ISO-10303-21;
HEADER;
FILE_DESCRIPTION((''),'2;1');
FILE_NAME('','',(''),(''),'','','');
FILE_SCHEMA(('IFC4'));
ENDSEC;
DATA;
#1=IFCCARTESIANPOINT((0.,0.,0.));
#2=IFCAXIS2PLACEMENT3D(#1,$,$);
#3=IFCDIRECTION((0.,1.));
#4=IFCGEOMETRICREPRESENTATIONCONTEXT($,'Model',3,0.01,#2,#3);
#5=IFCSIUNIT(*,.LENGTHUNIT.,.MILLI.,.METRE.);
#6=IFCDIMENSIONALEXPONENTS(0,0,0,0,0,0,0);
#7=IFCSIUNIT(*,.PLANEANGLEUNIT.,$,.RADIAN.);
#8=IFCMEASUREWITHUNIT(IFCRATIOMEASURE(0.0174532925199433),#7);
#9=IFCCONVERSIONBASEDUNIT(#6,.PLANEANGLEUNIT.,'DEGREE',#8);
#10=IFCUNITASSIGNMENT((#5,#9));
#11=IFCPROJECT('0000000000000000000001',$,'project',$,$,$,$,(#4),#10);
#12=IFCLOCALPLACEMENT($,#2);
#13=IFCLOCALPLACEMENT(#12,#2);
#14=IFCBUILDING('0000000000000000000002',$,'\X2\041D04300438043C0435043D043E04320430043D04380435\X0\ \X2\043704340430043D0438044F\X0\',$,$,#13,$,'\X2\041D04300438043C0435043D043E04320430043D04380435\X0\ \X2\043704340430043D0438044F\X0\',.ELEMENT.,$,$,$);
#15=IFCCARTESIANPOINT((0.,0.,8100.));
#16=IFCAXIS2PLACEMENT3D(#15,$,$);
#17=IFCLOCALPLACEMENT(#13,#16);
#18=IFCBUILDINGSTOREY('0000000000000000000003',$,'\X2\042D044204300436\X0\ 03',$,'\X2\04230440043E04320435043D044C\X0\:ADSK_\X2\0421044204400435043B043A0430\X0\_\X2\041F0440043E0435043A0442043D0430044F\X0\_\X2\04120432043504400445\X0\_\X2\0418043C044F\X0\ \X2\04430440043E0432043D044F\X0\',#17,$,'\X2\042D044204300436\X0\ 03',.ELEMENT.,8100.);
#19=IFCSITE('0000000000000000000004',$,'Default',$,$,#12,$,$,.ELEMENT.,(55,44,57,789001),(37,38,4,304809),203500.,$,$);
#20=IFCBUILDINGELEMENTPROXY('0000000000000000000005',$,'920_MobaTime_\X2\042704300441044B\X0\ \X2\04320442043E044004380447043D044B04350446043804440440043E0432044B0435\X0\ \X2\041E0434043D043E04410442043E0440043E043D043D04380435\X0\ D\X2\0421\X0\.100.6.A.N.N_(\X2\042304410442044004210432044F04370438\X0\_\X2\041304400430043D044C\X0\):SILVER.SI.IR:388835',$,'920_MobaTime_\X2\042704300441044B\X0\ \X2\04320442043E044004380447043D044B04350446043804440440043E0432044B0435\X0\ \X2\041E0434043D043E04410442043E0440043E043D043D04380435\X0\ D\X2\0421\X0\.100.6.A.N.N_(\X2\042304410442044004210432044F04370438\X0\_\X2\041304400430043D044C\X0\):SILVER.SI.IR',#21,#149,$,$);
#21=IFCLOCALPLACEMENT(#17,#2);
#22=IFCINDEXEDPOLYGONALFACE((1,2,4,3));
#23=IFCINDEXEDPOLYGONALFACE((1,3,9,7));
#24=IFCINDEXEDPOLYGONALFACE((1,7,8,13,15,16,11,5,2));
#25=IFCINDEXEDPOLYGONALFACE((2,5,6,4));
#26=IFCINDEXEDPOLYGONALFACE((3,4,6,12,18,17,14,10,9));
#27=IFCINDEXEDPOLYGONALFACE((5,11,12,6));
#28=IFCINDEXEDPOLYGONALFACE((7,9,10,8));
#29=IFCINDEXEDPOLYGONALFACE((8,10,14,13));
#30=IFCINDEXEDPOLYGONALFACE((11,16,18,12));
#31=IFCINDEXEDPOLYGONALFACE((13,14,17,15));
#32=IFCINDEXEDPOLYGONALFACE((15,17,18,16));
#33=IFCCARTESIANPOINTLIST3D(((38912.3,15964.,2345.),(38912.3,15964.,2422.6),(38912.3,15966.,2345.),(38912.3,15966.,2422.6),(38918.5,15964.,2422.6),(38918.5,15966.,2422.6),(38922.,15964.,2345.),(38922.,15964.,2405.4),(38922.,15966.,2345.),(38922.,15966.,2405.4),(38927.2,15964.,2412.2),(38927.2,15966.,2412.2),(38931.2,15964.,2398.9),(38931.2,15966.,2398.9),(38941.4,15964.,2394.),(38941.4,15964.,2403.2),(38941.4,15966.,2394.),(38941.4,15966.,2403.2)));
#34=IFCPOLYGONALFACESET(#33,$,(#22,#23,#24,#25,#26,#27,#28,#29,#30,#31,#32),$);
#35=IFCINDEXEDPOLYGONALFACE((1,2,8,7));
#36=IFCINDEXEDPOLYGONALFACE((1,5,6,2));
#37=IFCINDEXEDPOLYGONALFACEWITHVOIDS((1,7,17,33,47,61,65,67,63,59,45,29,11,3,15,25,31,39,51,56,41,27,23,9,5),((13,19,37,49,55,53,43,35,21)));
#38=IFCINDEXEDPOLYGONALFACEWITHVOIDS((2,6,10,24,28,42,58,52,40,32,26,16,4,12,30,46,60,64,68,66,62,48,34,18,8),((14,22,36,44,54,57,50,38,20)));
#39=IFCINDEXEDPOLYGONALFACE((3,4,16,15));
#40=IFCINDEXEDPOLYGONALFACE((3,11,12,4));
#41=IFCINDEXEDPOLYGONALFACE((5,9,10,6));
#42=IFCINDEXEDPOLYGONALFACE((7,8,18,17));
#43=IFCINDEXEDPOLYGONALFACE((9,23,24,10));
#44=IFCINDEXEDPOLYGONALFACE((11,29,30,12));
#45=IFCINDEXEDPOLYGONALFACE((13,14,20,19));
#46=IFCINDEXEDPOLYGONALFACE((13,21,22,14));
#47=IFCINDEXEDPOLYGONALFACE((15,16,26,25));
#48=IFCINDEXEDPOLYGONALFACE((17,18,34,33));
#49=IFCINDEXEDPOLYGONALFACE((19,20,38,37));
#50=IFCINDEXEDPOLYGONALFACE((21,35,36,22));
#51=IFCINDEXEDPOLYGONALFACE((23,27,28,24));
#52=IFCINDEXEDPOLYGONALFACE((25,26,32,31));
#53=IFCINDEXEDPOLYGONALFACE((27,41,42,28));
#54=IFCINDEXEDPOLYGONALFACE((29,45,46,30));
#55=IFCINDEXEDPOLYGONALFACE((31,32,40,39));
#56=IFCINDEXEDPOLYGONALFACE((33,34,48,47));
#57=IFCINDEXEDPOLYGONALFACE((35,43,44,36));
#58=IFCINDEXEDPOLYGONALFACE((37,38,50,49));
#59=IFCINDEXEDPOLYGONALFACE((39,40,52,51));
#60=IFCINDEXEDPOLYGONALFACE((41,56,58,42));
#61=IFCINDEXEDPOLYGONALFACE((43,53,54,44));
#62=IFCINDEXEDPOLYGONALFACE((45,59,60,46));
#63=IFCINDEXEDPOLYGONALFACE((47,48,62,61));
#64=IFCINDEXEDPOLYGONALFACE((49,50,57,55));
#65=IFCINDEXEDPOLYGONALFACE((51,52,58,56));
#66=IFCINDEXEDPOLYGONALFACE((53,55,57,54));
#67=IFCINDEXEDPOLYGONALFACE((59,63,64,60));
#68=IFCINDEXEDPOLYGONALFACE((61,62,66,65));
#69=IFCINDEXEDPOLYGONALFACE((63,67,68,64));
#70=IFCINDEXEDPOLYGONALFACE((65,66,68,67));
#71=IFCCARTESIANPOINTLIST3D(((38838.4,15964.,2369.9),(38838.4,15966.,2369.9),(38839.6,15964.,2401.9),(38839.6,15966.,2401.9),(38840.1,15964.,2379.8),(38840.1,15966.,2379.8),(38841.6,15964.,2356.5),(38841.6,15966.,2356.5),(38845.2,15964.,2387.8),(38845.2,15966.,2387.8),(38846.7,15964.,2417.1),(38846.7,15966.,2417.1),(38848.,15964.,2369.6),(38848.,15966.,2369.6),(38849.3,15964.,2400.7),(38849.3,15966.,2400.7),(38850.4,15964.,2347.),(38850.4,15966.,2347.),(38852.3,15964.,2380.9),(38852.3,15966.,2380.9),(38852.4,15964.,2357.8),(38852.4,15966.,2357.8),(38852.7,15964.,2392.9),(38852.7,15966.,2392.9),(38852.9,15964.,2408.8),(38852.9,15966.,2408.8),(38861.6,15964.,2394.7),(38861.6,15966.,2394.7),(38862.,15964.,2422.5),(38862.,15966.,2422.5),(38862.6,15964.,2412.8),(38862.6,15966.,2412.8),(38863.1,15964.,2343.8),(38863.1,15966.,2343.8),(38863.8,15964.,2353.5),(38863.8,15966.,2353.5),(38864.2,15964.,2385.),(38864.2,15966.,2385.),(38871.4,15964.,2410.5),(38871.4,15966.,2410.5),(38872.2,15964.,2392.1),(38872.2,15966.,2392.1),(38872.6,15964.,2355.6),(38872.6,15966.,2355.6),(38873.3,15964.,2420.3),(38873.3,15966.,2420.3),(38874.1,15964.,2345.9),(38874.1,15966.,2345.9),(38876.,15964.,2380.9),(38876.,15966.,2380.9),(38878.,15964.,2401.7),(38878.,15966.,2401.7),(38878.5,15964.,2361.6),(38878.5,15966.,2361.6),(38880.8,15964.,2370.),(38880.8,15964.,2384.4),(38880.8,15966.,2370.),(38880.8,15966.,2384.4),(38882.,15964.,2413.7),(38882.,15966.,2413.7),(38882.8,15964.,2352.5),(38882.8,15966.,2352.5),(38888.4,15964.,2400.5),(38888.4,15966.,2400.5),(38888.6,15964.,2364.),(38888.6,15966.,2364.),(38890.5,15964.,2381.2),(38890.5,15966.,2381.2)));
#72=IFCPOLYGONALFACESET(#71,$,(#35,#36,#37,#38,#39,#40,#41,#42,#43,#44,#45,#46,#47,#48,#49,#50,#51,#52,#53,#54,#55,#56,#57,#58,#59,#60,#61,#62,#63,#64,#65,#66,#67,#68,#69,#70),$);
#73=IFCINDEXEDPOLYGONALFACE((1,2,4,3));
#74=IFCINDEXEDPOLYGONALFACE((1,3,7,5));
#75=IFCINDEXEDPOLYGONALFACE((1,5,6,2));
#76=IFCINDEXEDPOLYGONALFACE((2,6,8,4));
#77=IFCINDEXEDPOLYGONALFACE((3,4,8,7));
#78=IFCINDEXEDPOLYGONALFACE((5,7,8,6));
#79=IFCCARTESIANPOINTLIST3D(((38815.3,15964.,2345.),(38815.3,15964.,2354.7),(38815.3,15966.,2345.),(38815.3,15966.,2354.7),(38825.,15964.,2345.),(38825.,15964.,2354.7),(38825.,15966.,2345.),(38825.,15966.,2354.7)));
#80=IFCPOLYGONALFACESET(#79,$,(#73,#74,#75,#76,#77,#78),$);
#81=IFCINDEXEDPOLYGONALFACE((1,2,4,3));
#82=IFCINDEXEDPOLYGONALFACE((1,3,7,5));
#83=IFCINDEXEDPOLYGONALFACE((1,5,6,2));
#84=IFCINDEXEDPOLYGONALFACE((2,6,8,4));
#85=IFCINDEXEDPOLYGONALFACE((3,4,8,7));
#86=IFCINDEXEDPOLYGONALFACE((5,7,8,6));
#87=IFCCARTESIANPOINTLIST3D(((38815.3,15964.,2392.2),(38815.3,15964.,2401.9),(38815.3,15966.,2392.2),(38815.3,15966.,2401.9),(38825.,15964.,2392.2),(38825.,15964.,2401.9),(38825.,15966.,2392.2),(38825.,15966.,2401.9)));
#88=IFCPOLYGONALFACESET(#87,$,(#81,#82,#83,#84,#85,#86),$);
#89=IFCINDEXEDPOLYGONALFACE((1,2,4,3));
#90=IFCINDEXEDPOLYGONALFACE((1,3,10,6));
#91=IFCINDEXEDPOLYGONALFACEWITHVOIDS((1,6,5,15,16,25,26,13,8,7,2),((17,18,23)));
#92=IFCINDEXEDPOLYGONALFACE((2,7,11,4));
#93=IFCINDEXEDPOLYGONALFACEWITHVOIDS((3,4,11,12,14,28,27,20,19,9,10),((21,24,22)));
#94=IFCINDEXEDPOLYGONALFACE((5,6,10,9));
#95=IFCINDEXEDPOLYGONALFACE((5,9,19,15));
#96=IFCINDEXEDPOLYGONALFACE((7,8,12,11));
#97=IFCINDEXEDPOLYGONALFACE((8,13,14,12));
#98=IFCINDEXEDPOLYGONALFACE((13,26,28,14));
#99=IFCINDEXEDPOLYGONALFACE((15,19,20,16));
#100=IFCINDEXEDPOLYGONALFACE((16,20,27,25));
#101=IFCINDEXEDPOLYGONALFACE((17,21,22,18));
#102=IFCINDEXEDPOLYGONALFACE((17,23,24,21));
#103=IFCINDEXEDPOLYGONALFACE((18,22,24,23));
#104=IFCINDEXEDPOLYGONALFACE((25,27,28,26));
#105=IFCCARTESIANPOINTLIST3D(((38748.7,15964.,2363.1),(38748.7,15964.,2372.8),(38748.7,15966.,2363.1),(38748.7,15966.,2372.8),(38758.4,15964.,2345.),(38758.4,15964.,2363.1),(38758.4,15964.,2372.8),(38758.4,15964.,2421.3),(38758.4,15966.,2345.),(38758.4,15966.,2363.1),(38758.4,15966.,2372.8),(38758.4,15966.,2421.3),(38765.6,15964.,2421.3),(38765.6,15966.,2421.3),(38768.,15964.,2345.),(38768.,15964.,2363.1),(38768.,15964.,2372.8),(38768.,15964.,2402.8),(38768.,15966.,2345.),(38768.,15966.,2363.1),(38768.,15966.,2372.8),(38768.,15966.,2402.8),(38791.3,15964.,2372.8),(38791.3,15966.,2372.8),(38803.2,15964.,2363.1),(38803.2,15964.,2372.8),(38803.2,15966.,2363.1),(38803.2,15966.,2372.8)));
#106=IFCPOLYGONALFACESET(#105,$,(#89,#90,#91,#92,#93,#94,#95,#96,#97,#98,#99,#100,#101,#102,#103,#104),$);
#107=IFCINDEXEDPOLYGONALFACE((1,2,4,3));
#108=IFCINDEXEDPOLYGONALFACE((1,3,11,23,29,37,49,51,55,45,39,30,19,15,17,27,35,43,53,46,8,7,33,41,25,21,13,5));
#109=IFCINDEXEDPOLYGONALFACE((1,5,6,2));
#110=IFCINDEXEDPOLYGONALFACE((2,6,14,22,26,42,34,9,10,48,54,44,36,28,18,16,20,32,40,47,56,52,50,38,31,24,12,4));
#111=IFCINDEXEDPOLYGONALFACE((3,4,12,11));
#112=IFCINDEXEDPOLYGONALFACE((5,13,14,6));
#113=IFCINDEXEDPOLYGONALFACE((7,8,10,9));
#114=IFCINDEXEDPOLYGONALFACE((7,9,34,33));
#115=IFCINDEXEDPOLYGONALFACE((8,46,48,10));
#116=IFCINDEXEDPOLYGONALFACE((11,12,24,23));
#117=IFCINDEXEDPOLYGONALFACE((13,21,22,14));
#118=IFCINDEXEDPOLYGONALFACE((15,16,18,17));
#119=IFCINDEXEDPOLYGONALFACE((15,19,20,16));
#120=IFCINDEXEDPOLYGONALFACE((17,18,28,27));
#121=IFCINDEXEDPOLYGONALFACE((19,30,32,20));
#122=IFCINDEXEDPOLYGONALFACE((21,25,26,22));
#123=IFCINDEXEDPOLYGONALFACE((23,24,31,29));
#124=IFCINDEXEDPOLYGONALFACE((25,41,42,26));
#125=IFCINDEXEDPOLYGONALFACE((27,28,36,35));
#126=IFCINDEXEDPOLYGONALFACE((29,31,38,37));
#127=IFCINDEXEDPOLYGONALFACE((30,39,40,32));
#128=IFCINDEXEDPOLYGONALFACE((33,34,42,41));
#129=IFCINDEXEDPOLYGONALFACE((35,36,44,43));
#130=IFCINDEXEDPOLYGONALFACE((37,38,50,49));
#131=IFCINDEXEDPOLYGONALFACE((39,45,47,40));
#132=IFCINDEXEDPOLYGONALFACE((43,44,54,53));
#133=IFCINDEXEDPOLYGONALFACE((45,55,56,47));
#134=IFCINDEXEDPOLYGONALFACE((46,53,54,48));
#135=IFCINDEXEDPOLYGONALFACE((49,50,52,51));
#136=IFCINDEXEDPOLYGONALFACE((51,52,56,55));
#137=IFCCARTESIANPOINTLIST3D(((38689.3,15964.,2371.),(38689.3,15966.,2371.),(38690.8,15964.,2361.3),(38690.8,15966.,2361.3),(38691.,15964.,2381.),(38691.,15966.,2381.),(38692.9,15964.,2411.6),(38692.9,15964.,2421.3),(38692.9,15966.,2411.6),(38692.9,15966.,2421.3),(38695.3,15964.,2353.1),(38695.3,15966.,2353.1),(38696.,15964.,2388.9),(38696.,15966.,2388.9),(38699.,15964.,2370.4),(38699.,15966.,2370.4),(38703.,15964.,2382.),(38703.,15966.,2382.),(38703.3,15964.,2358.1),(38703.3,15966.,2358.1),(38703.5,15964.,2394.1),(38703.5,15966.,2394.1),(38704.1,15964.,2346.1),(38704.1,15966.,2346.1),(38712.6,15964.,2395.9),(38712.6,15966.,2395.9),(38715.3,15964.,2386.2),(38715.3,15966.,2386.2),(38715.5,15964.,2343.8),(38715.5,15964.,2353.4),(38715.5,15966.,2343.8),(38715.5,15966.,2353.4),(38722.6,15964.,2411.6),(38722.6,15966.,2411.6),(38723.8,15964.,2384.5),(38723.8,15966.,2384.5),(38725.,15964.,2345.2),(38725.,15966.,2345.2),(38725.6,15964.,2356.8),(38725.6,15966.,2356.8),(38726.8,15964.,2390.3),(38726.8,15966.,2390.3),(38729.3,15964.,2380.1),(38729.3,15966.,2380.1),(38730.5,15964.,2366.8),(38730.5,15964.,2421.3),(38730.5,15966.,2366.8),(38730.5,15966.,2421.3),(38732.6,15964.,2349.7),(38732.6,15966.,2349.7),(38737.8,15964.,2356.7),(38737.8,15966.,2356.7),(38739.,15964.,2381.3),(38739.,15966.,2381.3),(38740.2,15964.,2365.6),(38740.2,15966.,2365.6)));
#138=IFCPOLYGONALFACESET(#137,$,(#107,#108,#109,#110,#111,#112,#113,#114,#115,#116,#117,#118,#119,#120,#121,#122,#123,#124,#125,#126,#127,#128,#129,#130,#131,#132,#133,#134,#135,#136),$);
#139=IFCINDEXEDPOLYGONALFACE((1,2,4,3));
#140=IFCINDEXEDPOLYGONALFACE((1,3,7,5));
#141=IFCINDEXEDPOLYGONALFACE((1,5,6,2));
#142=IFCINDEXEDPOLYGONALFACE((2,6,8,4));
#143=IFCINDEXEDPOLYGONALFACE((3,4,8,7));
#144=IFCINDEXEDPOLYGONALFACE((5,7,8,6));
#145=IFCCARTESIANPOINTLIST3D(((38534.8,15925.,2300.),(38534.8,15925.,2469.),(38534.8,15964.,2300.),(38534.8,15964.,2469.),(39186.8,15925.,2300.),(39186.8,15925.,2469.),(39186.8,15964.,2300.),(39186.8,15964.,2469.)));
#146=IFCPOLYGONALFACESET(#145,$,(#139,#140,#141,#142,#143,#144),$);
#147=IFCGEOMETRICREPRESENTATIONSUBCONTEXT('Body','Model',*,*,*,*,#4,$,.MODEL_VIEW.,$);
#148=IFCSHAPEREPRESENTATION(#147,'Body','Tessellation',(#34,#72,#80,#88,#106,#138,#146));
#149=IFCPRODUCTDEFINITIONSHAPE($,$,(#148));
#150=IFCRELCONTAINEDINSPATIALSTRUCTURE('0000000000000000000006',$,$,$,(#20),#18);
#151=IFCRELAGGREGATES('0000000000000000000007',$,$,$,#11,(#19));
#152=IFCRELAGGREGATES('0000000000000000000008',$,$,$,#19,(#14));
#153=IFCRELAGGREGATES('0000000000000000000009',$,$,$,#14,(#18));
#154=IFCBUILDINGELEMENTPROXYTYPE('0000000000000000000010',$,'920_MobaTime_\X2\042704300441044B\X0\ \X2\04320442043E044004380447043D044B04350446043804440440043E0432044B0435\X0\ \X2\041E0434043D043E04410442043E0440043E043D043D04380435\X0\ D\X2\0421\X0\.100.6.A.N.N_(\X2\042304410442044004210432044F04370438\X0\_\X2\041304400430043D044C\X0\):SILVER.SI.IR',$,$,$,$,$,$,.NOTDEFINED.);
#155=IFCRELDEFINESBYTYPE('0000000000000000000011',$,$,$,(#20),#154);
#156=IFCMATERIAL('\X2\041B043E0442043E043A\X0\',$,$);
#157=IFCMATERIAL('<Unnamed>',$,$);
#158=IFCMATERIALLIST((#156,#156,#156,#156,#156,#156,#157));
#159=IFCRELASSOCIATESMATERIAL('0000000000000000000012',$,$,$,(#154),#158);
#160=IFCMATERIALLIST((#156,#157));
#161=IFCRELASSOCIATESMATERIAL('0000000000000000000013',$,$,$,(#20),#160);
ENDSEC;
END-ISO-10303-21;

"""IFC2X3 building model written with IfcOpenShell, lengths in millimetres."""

from ifc_helpers import new_model, entity, si_unit, converted_unit, direction, frame, origin, origin_2d_with_axis, place, context, subcontext, project, spatial, polyline, rectangle, outline, extrude, source, transform, mapped, material, material_list, type_object, type_shapes, element, save


model = new_model("IFC2X3")

# Units and contexts
model_context = context("Model", 3, precision=0.01, world=origin(), true_north=direction((0.0, 1.0)))
body_context = subcontext(model_context, "Body", "Model", "MODEL_VIEW")
ifc_project = project(units=[si_unit("LENGTHUNIT", "METRE", prefix="MILLI"), converted_unit("PLANEANGLEUNIT", "DEGREE", entity("IfcRatioMeasure", 0.0174532925199433), si_unit("PLANEANGLEUNIT", "RADIAN"), dimensions=[0, 0, 0, 0, 0, 0, 0])], contexts=[model_context])

# Site, building, storey
site_placement = place(None, origin())
site = spatial("IfcSite", under=ifc_project, at=site_placement, Name="Default", CompositionType="ELEMENT", RefLatitude=(55, 44, 57, 789001), RefLongitude=(37, 38, 4, 304809), RefElevation=203500.0)
building_placement = place(site_placement, origin())
building = spatial("IfcBuilding", under=site, at=building_placement, Name="Наименование здания", LongName="Наименование здания", CompositionType="ELEMENT")
storey_placement = place(building_placement, frame((0.0, 0.0, 8100.0)))
storey = spatial("IfcBuildingStorey", under=building, at=storey_placement, Name="Этаж 03", ObjectType="Уровень:ADSK_Стрелка_Проектная_Вверх_Имя уровня", LongName="Этаж 03", CompositionType="ELEMENT", Elevation=8100.0)

# Building element proxy
ifc_material_1 = material(Name="Лоток")
ifc_material_2 = material(Name="<Unnamed>")
ifc_material_list_1 = material_list([ifc_material_1, ifc_material_1, ifc_material_1, ifc_material_1, ifc_material_1, ifc_material_1, ifc_material_2])
building_element_proxy_type = type_object("IfcBuildingElementProxyType", Name="920_MobaTime_Часы вторичныецифровые Односторонние DС.100.6.A.N.N_(УстрСвязи_Грань):SILVER.SI.IR", PredefinedType="NOTDEFINED", material=ifc_material_list_1)
shared_shape = source(origin(), body_context, "Body", "SweptSolid", [
    extrude(outline(polyline([(-49.3, -13.1), (28.2, -13.1), (28.2, -6.8), (17.9, 1.8), (8.8, 16.0), (-0.3, 16.0), (4.6, 5.8), (11.1, -3.4), (-49.3, -3.4), (-49.3, -13.1)])), frame((-64.6, 9.8, 39.0), z_axis=(0.0, 0.0, 1.0), x_axis=(0.0, 1.0, 0.0)), (0.0, 0.0, 1.0), 2.0),
    extrude(outline(polyline([(2.2, -27.6), (19.0, -27.6), (30.5, -16.1), (33.3, -4.9), (31.0, 5.8), (21.8, 17.2), (5.2, 27.3), (-11.1, 33.0), (-24.0, 32.7), (-33.6, 27.6), (-40.3, 18.6), (-42.8, 5.7), (-38.0, -6.3), (-27.2, -14.9), (-17.5, -17.7), (-8.2, -16.4), (-0.3, -11.9), (5.1, -4.5), (7.3, 6.2), (4.0, 17.2), (18.4, 7.3), (23.6, -2.4), (22.0, -11.4), (14.2, -18.4), (5.3, -18.3), (2.2, -27.6)]), holes=[polyline([(-9.0, 23.3), (-1.3, 14.3), (-2.5, 2.0), (-11.4, -7.0), (-23.4, -6.0), (-32.2, 2.9), (-31.2, 15.1), (-25.6, 22.1), (-17.5, 24.9), (-9.0, 23.3)])]), frame((-2.7, 3.6, 39.0), z_axis=(0.0, 0.0, 1.0), x_axis=(-0.427649, 0.903945, 0.0)), (0.0, 0.0, 1.0), 2.0),
    extrude(rectangle(XDim=9.7, YDim=9.7, at=origin_2d_with_axis()), frame((40.6, -34.7, 39.0)), (0.0, 0.0, 1.0), 2.0),
    extrude(rectangle(XDim=9.7, YDim=9.7, at=origin_2d_with_axis()), frame((40.6, 12.6, 39.0)), (0.0, 0.0, 1.0), 2.0),
    extrude(outline(polyline([(-0.9, -28.1), (8.8, -28.1), (8.8, -9.9), (18.5, -9.9), (18.5, -0.2), (8.8, -0.2), (8.8, 48.3), (1.5, 48.3), (-36.0, -0.2), (-36.0, -9.9), (-0.9, -9.9), (-0.9, -28.1)]), holes=[polyline([(-0.9, -0.2), (-24.1, -0.2), (-0.9, 29.7), (-0.9, -0.2)])]), frame((93.6, -11.4, 39.0)), (0.0, 0.0, 1.0), 2.0),
    extrude(outline(polyline([(3.3, -28.3), (12.5, -28.3), (20.5, -25.0), (26.8, -18.9), (30.7, -10.0), (31.4, 1.6), (26.9, 11.8), (20.1, 18.4), (11.1, 22.3), (1.0, 23.3), (-7.9, 20.4), (-14.9, 14.5), (-18.9, 6.2), (-17.1, -9.0), (-36.7, 0.5), (-29.1, 29.2), (-38.5, 31.7), (-48.1, -4.6), (-11.6, -23.1), (-8.0, -14.0), (-10.8, -7.6), (-10.2, 1.1), (-3.0, 11.8), (9.2, 12.8), (20.0, 5.5), (21.4, -7.5), (15.5, -16.4), (4.6, -18.6), (3.3, -28.3)])), frame((147.1, -8.5, 39.0), z_axis=(0.0, 0.0, 1.0), x_axis=(0.256974, -0.966418, 0.0)), (0.0, 0.0, 1.0), 2.0),
    extrude(rectangle(XDim=652.0, YDim=169.0, at=origin_2d_with_axis()), frame((0.0, 0.0, 0.0), z_axis=(0.0, 0.0, 1.0), x_axis=(-1.0, 0.0, 0.0)), (0.0, 0.0, 1.0), 39.0),
])
type_shapes(building_element_proxy_type, [shared_shape])
ifc_material_list_2 = material_list([ifc_material_1, ifc_material_2])
for number, where, z_axis, x_axis, name in (
    (1, (38860.8, 15925.0, 2384.5), (0.0, 1.0, 0.0), (-1.0, 0.0, 0.0), "920_MobaTime_Часы вторичныецифровые Односторонние DС.100.6.A.N.N_(УстрСвязи_Грань):SILVER.SI.IR:388835"),
):
    element("IfcBuildingElementProxy", number, at=place(storey_placement, frame(where, z_axis=z_axis, x_axis=x_axis)), inside=storey, type_object=building_element_proxy_type, material=ifc_material_list_2, Name=name, ObjectType="920_MobaTime_Часы вторичныецифровые Односторонние DС.100.6.A.N.N_(УстрСвязи_Грань):SILVER.SI.IR", context=body_context, shape_type="MappedRepresentation", body=[
        mapped(shared_shape, transform((0.0, 0.0, 0.0), scale=1.0)),
    ])

save(model, "model.ifc")
